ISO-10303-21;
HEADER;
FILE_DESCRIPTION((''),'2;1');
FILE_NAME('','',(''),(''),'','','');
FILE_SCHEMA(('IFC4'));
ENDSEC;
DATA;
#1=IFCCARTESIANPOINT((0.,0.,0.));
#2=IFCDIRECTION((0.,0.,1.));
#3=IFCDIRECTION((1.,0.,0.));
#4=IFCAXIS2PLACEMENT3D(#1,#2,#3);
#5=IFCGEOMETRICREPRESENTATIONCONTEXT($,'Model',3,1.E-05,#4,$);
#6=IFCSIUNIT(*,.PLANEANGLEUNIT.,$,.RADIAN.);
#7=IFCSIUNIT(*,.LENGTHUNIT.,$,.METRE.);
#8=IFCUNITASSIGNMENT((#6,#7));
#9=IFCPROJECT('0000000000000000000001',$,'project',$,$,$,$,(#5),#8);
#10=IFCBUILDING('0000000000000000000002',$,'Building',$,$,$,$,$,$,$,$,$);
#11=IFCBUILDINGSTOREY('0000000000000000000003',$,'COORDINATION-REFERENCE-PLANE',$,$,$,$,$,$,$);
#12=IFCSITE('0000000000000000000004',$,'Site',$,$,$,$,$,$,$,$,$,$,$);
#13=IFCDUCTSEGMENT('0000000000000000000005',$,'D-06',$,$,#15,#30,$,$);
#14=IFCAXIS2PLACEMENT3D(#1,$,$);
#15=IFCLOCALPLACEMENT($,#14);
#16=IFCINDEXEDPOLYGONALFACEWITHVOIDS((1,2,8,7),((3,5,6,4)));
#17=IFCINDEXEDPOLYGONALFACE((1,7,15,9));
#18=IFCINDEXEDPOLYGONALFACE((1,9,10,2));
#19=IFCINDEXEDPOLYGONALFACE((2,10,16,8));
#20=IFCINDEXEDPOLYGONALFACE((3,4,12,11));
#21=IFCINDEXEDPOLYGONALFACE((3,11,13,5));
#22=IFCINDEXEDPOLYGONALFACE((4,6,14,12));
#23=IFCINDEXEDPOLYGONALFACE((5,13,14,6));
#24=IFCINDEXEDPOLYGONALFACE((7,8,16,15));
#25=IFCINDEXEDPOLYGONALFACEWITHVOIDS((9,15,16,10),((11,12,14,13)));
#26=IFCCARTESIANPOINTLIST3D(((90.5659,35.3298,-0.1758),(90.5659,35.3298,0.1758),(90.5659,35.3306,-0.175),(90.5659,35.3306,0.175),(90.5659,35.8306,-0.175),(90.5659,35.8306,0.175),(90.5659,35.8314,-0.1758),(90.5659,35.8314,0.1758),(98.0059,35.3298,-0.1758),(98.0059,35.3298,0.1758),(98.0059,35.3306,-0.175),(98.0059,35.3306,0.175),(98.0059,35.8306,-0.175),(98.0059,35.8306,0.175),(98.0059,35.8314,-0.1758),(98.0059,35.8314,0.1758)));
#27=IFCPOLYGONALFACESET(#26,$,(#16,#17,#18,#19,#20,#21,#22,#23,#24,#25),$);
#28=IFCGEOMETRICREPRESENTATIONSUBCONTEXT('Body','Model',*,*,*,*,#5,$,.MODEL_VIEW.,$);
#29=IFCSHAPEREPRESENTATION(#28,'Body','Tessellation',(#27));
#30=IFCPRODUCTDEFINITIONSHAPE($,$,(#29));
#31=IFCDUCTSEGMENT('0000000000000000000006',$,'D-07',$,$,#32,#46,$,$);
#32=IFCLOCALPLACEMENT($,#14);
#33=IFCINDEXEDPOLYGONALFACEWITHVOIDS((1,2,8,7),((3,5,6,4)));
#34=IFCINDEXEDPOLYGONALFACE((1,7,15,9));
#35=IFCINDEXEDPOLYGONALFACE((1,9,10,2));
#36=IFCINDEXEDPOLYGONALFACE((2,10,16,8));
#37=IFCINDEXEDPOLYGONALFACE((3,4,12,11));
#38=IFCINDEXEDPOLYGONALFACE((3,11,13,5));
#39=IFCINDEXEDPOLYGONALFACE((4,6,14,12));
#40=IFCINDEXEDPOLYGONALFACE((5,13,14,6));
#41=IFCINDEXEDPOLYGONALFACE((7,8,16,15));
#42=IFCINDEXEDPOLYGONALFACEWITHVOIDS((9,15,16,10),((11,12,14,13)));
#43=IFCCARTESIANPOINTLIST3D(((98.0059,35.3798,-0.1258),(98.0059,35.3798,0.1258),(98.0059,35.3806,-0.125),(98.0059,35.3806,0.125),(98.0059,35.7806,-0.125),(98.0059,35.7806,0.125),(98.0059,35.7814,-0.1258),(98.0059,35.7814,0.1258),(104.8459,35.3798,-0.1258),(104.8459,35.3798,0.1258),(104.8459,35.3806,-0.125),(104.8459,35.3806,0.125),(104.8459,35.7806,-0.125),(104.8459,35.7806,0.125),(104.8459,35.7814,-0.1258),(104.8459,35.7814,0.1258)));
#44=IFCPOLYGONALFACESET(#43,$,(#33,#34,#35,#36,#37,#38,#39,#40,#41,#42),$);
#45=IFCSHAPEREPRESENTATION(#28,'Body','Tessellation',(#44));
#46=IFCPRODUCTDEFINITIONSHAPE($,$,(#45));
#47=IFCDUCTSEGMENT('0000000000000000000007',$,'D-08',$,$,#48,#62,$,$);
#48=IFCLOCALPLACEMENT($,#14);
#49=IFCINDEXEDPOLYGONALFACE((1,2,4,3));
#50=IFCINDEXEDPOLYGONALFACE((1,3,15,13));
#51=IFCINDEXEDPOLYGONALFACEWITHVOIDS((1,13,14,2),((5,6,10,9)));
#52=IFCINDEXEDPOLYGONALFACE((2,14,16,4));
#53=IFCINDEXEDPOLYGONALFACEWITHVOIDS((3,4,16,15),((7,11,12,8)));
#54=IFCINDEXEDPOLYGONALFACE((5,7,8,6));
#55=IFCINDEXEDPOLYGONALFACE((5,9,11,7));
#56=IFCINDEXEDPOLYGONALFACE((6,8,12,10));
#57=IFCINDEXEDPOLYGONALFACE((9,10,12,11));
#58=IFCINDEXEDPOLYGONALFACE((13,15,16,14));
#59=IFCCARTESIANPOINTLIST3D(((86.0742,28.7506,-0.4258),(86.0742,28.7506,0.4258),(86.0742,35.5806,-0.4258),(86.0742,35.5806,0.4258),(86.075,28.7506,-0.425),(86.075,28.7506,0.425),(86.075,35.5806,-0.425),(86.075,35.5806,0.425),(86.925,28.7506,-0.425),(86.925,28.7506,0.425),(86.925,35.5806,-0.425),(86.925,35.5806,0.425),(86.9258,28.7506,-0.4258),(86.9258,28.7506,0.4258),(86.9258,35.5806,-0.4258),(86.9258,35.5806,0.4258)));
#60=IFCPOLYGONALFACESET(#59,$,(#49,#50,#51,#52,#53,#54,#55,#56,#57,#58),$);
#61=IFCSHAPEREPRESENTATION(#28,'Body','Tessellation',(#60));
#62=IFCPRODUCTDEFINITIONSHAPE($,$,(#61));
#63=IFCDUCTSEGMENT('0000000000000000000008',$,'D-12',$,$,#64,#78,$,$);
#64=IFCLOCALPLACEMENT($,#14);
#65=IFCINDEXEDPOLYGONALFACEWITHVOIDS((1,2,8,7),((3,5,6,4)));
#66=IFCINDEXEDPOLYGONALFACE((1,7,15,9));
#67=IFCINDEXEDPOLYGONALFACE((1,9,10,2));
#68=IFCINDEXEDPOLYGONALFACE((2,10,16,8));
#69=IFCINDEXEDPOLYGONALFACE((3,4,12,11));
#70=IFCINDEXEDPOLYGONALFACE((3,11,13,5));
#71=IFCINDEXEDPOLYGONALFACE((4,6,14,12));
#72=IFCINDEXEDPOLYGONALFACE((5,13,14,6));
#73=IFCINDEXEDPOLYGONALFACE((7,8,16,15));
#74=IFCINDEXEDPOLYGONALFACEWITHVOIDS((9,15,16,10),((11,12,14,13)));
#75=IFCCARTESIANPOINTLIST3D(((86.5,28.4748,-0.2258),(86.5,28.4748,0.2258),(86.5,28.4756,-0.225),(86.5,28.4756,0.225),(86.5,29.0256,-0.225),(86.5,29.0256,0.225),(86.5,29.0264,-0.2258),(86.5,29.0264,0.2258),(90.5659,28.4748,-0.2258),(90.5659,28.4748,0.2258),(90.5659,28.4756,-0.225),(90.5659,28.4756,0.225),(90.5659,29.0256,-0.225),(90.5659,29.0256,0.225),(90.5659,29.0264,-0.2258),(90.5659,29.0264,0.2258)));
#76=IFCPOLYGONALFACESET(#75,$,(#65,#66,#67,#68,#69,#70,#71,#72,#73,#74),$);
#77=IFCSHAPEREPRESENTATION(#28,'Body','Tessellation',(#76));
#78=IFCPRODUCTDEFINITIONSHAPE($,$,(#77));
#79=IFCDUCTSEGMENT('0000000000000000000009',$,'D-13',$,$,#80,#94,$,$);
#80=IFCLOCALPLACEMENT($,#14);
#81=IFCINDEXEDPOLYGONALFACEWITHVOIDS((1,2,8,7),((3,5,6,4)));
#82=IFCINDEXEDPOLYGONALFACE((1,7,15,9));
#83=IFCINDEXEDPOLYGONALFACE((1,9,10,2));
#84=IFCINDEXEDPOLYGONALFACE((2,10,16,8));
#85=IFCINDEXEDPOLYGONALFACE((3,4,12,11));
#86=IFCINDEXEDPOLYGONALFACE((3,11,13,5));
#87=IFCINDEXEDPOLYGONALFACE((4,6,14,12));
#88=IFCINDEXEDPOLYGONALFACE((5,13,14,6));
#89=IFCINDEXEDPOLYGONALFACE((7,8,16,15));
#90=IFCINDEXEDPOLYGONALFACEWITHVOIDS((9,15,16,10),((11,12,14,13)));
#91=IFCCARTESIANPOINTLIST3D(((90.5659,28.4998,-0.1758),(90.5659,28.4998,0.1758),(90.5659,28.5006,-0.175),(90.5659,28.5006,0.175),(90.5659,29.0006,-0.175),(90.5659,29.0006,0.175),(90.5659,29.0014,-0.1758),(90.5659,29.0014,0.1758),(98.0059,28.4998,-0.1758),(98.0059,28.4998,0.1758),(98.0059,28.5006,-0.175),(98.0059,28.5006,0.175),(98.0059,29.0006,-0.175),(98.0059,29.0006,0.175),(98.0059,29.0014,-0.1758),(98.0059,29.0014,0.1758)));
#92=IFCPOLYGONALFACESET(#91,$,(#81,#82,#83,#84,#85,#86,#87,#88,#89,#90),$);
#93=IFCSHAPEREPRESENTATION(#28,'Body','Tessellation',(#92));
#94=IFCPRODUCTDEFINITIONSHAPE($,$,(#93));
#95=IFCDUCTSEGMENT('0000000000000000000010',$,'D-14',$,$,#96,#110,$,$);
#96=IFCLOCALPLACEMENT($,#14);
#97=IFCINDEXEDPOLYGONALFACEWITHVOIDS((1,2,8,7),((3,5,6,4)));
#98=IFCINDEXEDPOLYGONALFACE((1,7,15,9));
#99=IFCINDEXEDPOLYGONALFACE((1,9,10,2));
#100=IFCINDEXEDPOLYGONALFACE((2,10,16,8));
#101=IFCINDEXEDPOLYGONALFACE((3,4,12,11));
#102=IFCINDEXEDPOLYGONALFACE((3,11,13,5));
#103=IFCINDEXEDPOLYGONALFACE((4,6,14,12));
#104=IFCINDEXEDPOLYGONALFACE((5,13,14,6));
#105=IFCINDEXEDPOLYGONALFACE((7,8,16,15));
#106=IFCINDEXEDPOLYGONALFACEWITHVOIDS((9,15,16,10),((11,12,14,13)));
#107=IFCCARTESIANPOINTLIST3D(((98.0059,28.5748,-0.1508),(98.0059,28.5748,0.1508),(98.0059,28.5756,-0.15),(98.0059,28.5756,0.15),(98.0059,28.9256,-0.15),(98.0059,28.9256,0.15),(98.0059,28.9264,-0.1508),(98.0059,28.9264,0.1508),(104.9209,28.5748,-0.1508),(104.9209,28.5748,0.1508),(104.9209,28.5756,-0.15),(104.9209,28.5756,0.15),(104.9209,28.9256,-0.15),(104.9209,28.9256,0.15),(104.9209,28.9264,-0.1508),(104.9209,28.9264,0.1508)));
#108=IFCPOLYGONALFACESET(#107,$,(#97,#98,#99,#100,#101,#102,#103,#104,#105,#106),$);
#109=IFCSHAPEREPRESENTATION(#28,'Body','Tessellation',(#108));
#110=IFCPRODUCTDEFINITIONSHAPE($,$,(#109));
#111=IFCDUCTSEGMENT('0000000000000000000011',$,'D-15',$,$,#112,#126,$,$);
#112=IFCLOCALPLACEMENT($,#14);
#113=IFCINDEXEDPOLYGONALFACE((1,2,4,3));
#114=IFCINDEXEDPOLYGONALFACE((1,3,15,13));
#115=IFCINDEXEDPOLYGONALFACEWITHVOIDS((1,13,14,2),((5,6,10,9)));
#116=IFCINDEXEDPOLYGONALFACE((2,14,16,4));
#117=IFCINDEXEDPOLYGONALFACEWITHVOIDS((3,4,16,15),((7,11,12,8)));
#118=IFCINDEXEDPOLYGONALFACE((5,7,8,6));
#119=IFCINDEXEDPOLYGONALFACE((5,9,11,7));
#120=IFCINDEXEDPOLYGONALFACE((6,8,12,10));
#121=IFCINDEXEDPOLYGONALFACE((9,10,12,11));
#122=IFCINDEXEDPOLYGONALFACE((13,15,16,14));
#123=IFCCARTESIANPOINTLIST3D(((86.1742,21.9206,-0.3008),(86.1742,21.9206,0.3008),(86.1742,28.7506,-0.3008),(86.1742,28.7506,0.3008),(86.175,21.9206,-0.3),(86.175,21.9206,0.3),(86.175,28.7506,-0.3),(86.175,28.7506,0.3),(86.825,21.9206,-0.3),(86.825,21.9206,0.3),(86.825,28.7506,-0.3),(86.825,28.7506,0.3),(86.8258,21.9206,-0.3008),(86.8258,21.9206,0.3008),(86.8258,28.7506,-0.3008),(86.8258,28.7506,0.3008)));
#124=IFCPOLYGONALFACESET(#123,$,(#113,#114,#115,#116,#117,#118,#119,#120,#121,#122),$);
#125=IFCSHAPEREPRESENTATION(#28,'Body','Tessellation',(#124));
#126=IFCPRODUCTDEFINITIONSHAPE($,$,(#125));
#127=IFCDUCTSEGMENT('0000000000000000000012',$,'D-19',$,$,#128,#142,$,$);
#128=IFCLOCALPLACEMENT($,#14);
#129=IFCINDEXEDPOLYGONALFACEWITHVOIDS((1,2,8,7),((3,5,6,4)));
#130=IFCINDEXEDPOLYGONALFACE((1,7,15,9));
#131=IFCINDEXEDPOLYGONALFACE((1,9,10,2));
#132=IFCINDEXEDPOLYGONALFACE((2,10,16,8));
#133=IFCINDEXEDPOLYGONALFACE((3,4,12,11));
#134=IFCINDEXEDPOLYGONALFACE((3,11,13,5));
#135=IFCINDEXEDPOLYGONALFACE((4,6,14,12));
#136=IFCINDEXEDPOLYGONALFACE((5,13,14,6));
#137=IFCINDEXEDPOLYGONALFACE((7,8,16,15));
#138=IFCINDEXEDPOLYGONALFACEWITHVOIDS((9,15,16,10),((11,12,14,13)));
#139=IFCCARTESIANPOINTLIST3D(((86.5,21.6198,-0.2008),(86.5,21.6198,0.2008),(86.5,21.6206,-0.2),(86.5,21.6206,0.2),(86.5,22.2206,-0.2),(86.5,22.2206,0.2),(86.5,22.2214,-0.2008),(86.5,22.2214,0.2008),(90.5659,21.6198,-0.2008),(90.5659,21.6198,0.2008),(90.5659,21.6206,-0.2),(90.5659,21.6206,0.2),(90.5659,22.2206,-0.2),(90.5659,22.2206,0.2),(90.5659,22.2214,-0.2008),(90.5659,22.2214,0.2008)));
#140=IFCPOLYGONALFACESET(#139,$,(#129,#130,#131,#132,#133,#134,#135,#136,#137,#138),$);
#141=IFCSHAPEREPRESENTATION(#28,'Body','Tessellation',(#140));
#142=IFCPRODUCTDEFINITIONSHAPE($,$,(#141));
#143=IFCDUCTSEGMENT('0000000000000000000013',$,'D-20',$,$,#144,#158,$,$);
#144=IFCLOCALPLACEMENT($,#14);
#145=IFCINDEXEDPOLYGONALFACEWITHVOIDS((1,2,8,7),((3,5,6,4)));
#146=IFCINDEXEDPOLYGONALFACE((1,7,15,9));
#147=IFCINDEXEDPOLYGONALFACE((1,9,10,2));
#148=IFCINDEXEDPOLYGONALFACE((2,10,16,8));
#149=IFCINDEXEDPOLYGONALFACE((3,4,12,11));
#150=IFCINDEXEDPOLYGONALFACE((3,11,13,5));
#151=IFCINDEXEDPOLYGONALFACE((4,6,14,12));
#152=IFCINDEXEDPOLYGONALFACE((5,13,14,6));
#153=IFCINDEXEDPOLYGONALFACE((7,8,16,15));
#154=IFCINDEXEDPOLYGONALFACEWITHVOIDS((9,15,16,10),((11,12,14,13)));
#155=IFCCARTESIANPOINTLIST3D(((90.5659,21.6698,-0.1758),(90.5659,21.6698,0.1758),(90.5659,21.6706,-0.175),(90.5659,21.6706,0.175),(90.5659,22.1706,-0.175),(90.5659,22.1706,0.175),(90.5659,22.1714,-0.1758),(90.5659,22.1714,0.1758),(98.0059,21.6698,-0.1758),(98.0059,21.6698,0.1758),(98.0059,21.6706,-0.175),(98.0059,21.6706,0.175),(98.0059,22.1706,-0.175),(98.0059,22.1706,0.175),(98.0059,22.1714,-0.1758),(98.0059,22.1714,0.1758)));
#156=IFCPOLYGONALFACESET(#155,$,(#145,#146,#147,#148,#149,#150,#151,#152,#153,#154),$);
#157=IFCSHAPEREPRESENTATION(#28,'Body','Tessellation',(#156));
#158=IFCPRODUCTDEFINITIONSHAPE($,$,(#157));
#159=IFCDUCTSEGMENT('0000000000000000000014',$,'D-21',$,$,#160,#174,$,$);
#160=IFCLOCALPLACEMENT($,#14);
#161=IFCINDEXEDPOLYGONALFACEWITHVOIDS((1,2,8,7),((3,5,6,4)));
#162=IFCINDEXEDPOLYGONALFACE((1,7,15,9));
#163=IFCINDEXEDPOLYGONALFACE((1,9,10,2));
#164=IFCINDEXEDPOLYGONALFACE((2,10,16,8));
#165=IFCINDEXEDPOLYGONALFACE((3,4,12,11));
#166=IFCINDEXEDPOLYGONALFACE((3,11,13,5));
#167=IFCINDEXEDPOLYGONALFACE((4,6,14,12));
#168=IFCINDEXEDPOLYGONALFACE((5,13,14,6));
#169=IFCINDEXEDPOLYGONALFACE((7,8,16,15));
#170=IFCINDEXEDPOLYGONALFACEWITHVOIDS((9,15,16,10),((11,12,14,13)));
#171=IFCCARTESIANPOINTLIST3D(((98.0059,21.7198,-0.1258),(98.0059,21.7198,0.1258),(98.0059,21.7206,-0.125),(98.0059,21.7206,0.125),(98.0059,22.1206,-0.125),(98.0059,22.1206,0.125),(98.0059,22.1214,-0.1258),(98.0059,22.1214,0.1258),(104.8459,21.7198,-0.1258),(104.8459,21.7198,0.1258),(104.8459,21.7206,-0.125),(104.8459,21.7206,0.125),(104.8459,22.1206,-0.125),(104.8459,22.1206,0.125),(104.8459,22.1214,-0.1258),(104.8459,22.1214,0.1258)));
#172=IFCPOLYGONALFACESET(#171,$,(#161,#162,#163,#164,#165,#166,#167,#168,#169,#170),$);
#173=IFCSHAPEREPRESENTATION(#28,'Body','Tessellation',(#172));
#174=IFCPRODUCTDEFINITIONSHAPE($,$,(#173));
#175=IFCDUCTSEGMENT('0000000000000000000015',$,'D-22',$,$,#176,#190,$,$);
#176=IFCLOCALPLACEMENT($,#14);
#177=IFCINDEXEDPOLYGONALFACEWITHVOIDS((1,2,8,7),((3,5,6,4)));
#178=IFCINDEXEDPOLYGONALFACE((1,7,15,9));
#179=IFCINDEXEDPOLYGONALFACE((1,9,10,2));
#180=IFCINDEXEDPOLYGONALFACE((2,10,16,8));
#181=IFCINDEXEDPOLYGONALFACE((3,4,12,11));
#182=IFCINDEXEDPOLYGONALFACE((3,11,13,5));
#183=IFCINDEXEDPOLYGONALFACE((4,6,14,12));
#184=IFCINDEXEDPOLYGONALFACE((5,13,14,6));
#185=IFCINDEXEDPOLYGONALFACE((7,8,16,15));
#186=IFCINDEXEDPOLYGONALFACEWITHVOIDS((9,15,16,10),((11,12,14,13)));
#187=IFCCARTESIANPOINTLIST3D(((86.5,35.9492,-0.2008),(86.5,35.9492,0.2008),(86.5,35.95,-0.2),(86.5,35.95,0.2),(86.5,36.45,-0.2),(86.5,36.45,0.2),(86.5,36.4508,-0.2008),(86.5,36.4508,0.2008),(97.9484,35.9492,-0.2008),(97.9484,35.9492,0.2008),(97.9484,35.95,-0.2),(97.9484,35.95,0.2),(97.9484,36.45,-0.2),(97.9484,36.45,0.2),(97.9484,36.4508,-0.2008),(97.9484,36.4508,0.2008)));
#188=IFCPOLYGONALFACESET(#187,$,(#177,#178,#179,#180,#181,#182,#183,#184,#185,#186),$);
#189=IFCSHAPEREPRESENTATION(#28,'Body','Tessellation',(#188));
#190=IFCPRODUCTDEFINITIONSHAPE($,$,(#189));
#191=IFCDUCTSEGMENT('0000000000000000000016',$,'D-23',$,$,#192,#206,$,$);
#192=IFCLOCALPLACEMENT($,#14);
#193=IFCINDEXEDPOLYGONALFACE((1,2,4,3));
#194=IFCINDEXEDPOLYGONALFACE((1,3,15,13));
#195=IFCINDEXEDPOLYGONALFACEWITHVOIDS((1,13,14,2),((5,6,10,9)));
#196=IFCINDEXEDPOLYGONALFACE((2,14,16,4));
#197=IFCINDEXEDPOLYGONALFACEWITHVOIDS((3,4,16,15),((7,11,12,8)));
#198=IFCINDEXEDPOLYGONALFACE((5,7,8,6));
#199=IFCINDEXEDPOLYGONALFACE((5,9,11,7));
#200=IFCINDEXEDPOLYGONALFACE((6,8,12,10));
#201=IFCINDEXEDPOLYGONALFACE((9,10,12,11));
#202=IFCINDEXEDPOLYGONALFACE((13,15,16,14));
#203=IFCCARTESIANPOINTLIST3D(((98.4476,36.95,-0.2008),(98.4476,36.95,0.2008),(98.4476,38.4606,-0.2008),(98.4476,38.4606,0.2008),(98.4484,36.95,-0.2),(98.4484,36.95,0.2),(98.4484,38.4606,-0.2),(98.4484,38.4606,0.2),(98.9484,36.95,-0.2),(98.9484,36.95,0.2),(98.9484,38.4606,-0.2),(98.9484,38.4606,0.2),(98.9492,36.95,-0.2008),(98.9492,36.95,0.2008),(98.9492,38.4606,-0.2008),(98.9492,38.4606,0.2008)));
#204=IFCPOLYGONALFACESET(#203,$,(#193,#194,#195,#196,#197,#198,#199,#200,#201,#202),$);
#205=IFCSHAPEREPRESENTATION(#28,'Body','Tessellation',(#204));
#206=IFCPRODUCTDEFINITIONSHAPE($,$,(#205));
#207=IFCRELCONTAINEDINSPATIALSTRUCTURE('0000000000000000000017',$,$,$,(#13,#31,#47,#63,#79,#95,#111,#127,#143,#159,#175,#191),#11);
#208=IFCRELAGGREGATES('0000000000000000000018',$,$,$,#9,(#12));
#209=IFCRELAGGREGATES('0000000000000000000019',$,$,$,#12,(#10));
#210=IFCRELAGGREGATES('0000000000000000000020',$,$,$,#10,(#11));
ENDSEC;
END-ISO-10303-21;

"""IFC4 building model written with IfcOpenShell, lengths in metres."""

from ifc_helpers import new_model, si_unit, frame, origin, origin_with_axes, place, context, subcontext, project, spatial, hollow_rectangle, extrude, element, save


model = new_model("IFC4")

# Units and contexts
model_context = context("Model", 3, precision=1e-05, world=origin_with_axes())
body_context = subcontext(model_context, "Body", "Model", "MODEL_VIEW")
ifc_project = project(units=[si_unit("PLANEANGLEUNIT", "RADIAN"), si_unit("LENGTHUNIT", "METRE")], contexts=[model_context])

# Site, building, storey
site = spatial("IfcSite", under=ifc_project, Name="Site")
building = spatial("IfcBuilding", under=site, Name="Building")
storey = spatial("IfcBuildingStorey", under=building, Name="COORDINATION-REFERENCE-PLANE")

# Duct segments
duct_segment_1_placement = place(None, frame((90.5659, 35.5806, 0.0), z_axis=(1.0, 0.0, 0.0), x_axis=(0.0, 1.0, 0.0)))
element("IfcDuctSegment", 1, at=duct_segment_1_placement, inside=storey, Name="D-06", context=body_context, shape_type="SweptSolid", body=[
    extrude(hollow_rectangle(XDim=0.5016, YDim=0.3516, WallThickness=0.0008), origin(), (0.0, 0.0, 1.0), 7.44),
])
duct_segment_2_placement = place(None, frame((98.0059, 35.5806, 0.0), z_axis=(1.0, 0.0, 0.0), x_axis=(0.0, 1.0, 0.0)))
element("IfcDuctSegment", 2, at=duct_segment_2_placement, inside=storey, Name="D-07", context=body_context, shape_type="SweptSolid", body=[
    extrude(hollow_rectangle(XDim=0.4016, YDim=0.2516, WallThickness=0.0008), origin(), (0.0, 0.0, 1.0), 6.84),
])
duct_segment_3_placement = place(None, frame((86.5, 28.7506, 0.0), z_axis=(0.0, 1.0, 0.0), x_axis=(1.0, 0.0, 0.0)))
element("IfcDuctSegment", 3, at=duct_segment_3_placement, inside=storey, Name="D-08", context=body_context, shape_type="SweptSolid", body=[
    extrude(hollow_rectangle(XDim=0.8516, YDim=0.8516, WallThickness=0.0008), origin(), (0.0, 0.0, 1.0), 6.83),
])
duct_segment_4_placement = place(None, frame((86.5, 28.7506, 0.0), z_axis=(1.0, 0.0, 0.0), x_axis=(0.0, 1.0, 0.0)))
element("IfcDuctSegment", 4, at=duct_segment_4_placement, inside=storey, Name="D-12", context=body_context, shape_type="SweptSolid", body=[
    extrude(hollow_rectangle(XDim=0.5516, YDim=0.4516, WallThickness=0.0008), origin(), (0.0, 0.0, 1.0), 4.0659),
])
duct_segment_5_placement = place(None, frame((90.5659, 28.7506, 0.0), z_axis=(1.0, 0.0, 0.0), x_axis=(0.0, 1.0, 0.0)))
element("IfcDuctSegment", 5, at=duct_segment_5_placement, inside=storey, Name="D-13", context=body_context, shape_type="SweptSolid", body=[
    extrude(hollow_rectangle(XDim=0.5016, YDim=0.3516, WallThickness=0.0008), origin(), (0.0, 0.0, 1.0), 7.44),
])
duct_segment_6_placement = place(None, frame((98.0059, 28.7506, 0.0), z_axis=(1.0, 0.0, 0.0), x_axis=(0.0, 1.0, 0.0)))
element("IfcDuctSegment", 6, at=duct_segment_6_placement, inside=storey, Name="D-14", context=body_context, shape_type="SweptSolid", body=[
    extrude(hollow_rectangle(XDim=0.3516, YDim=0.3016, WallThickness=0.0008), origin(), (0.0, 0.0, 1.0), 6.915),
])
duct_segment_7_placement = place(None, frame((86.5, 21.9206, 0.0), z_axis=(0.0, 1.0, 0.0), x_axis=(1.0, 0.0, 0.0)))
element("IfcDuctSegment", 7, at=duct_segment_7_placement, inside=storey, Name="D-15", context=body_context, shape_type="SweptSolid", body=[
    extrude(hollow_rectangle(XDim=0.6516, YDim=0.6016, WallThickness=0.0008), origin(), (0.0, 0.0, 1.0), 6.83),
])
duct_segment_8_placement = place(None, frame((86.5, 21.9206, 0.0), z_axis=(1.0, 0.0, 0.0), x_axis=(0.0, 1.0, 0.0)))
element("IfcDuctSegment", 8, at=duct_segment_8_placement, inside=storey, Name="D-19", context=body_context, shape_type="SweptSolid", body=[
    extrude(hollow_rectangle(XDim=0.6016, YDim=0.4016, WallThickness=0.0008), origin(), (0.0, 0.0, 1.0), 4.0659),
])
duct_segment_9_placement = place(None, frame((90.5659, 21.9206, 0.0), z_axis=(1.0, 0.0, 0.0), x_axis=(0.0, 1.0, 0.0)))
element("IfcDuctSegment", 9, at=duct_segment_9_placement, inside=storey, Name="D-20", context=body_context, shape_type="SweptSolid", body=[
    extrude(hollow_rectangle(XDim=0.5016, YDim=0.3516, WallThickness=0.0008), origin(), (0.0, 0.0, 1.0), 7.44),
])
duct_segment_10_placement = place(None, frame((98.0059, 21.9206, 0.0), z_axis=(1.0, 0.0, 0.0), x_axis=(0.0, 1.0, 0.0)))
element("IfcDuctSegment", 10, at=duct_segment_10_placement, inside=storey, Name="D-21", context=body_context, shape_type="SweptSolid", body=[
    extrude(hollow_rectangle(XDim=0.4016, YDim=0.2516, WallThickness=0.0008), origin(), (0.0, 0.0, 1.0), 6.84),
])
duct_segment_11_placement = place(None, frame((86.5, 36.2, 0.0), z_axis=(1.0, 0.0, 0.0), x_axis=(0.0, 1.0, 0.0)))
element("IfcDuctSegment", 11, at=duct_segment_11_placement, inside=storey, Name="D-22", context=body_context, shape_type="SweptSolid", body=[
    extrude(hollow_rectangle(XDim=0.5016, YDim=0.4016, WallThickness=0.0008), origin(), (0.0, 0.0, 1.0), 11.4484),
])
duct_segment_12_placement = place(None, frame((98.6984, 36.95, 0.0), z_axis=(0.0, 1.0, 0.0), x_axis=(1.0, 0.0, 0.0)))
element("IfcDuctSegment", 12, at=duct_segment_12_placement, inside=storey, Name="D-23", context=body_context, shape_type="SweptSolid", body=[
    extrude(hollow_rectangle(XDim=0.5016, YDim=0.4016, WallThickness=0.0008), origin(), (0.0, 0.0, 1.0), 1.5106),
])

save(model, "model.ifc")
